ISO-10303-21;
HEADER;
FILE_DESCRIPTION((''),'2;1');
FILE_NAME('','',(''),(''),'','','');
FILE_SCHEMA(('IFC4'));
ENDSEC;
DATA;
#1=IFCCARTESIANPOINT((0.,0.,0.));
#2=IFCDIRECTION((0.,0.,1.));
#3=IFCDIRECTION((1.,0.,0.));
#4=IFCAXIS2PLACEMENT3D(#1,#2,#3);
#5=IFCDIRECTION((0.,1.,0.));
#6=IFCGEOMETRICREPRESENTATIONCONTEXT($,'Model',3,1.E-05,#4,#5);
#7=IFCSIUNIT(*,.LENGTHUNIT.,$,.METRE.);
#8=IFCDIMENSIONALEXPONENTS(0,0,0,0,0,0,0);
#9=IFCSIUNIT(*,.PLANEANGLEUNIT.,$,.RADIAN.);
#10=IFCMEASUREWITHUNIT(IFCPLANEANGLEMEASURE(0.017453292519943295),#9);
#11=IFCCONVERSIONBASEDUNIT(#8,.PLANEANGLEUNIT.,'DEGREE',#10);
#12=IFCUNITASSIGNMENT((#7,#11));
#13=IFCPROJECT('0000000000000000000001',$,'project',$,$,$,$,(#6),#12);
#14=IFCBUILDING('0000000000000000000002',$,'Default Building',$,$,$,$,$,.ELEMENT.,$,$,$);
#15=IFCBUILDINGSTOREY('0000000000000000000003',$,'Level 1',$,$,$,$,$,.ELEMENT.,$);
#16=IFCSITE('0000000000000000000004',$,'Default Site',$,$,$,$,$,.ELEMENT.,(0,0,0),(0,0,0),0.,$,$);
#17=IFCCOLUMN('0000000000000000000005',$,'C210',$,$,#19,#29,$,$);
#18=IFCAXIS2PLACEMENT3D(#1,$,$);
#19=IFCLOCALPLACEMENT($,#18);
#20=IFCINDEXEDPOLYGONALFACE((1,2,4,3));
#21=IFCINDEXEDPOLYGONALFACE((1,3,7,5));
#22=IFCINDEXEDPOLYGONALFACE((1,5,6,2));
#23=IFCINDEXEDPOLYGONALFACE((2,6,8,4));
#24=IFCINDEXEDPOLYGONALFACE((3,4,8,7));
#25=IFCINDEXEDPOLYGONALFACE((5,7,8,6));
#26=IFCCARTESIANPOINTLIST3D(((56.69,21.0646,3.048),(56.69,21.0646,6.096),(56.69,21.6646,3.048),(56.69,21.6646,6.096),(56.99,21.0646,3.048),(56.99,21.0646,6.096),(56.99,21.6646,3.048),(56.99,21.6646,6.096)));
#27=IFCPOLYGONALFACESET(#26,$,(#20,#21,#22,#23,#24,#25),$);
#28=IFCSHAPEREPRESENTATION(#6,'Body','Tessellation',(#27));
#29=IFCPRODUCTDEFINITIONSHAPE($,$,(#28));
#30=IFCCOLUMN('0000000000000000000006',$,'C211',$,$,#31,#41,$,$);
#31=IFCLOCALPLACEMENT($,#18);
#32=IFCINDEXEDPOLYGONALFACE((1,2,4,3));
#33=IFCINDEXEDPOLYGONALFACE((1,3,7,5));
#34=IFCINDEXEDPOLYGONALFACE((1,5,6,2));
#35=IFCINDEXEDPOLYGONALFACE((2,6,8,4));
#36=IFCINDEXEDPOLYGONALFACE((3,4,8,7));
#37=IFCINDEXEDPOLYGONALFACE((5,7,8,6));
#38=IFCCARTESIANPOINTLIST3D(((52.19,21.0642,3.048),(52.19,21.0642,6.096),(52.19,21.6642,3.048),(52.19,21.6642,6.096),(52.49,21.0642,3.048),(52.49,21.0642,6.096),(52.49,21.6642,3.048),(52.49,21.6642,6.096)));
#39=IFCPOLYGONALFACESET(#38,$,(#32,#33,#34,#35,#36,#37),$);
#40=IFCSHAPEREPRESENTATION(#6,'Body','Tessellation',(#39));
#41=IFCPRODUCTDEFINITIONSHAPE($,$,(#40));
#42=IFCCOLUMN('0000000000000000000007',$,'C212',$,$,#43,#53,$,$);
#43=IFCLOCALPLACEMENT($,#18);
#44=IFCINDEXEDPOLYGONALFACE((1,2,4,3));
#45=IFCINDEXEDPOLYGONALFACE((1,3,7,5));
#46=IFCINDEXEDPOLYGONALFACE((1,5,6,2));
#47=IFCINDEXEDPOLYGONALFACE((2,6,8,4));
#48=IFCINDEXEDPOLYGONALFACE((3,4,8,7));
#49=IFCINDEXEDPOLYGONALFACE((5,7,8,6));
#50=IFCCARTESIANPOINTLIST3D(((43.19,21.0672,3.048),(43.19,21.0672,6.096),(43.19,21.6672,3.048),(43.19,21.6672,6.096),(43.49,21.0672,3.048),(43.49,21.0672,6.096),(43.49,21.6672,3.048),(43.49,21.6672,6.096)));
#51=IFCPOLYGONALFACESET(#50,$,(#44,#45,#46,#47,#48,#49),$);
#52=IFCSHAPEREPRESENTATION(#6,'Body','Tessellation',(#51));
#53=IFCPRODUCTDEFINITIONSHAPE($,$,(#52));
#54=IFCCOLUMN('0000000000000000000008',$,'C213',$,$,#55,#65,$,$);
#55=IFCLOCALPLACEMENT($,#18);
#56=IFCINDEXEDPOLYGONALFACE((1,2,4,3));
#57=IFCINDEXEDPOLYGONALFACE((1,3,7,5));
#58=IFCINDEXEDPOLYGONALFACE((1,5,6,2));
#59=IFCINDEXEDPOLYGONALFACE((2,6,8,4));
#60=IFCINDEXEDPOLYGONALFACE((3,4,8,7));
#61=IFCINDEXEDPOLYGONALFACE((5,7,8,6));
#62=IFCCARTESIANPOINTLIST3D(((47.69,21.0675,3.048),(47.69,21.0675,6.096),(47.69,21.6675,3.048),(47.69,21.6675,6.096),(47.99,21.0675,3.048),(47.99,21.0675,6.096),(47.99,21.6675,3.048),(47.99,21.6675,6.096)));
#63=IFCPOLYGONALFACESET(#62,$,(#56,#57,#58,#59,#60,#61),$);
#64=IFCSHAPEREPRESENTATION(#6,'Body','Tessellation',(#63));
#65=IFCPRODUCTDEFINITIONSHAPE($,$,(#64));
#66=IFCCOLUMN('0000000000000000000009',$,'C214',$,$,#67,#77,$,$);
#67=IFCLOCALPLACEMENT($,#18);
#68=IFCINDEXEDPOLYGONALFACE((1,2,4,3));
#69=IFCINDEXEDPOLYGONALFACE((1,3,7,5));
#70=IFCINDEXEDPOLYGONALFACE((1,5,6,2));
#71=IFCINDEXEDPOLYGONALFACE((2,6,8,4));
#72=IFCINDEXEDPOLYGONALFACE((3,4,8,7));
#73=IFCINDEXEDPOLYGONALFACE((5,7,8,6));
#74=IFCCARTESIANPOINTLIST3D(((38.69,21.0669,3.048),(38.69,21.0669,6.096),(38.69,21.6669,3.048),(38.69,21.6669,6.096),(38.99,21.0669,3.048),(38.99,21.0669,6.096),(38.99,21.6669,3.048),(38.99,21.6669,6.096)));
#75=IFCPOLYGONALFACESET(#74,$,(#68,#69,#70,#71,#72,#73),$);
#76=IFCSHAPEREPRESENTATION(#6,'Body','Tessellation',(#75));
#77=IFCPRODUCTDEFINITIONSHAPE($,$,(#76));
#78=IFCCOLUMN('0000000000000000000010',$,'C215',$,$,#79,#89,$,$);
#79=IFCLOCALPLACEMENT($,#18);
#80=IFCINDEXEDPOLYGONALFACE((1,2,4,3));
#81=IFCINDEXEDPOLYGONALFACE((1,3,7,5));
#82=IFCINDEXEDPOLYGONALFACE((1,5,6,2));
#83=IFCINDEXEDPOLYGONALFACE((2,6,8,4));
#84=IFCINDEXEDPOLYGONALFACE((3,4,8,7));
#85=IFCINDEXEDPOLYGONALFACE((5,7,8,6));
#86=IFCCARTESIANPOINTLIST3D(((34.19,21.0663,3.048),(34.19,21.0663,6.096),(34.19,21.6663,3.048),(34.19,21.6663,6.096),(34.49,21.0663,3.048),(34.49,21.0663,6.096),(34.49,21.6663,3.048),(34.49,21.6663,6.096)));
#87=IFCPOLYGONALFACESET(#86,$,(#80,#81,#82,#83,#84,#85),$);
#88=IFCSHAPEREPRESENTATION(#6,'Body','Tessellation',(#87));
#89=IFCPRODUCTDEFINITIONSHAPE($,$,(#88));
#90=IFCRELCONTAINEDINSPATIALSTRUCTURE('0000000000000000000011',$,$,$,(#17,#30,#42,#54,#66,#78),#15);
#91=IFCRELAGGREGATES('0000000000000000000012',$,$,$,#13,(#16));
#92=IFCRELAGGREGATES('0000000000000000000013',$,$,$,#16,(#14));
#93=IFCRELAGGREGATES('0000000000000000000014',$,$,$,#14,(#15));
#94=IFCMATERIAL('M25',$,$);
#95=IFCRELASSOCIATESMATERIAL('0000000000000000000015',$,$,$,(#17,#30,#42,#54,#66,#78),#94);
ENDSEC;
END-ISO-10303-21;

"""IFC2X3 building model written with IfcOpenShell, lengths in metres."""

from ifc_helpers import new_model, entity, si_unit, converted_unit, direction, frame, frame_2d, origin_with_axes, place, context, project, spatial, rectangle, extrude, material, element, save


model = new_model("IFC2X3")

# Units and contexts
model_context = context("Model", 3, precision=1e-05, world=origin_with_axes(), true_north=direction((0.0, 1.0, 0.0)))
ifc_project = project(units=[si_unit("LENGTHUNIT", "METRE"), converted_unit("PLANEANGLEUNIT", "DEGREE", entity("IfcPlaneAngleMeasure", 0.017453292519943295), si_unit("PLANEANGLEUNIT", "RADIAN"), dimensions=[0, 0, 0, 0, 0, 0, 0])], contexts=[model_context])

# Site, building, storey
site = spatial("IfcSite", under=ifc_project, Name="Default Site", CompositionType="ELEMENT", RefLatitude=(0, 0, 0), RefLongitude=(0, 0, 0), RefElevation=0.0)
building = spatial("IfcBuilding", under=site, Name="Default Building", CompositionType="ELEMENT")
storey = spatial("IfcBuildingStorey", under=building, Name="Level 1", CompositionType="ELEMENT")

# Columns
ifc_material = material(Name="M25")
placement = place(None, origin_with_axes())
element("IfcColumn", 1, at=placement, inside=storey, material=ifc_material, Name="C210", context=model_context, shape_type="SweptSolid", body=[
    extrude(rectangle(XDim=0.3, YDim=0.6, at=frame_2d((0.0, 0.0), x_axis=(1.0, 0.0, 0.0))), frame((56.84, 21.3646, 3.048), z_axis=(0.0, 0.0, 1.0), x_axis=(1.0, 0.0, 0.0)), (0.0, 0.0, 1.0), 3.048),
])
element("IfcColumn", 2, at=placement, inside=storey, material=ifc_material, Name="C211", context=model_context, shape_type="SweptSolid", body=[
    extrude(rectangle(XDim=0.3, YDim=0.6, at=frame_2d((0.0, 0.0), x_axis=(1.0, 0.0, 0.0))), frame((52.34, 21.3642, 3.048), z_axis=(0.0, 0.0, 1.0), x_axis=(1.0, 0.0, 0.0)), (0.0, 0.0, 1.0), 3.048),
])
element("IfcColumn", 3, at=placement, inside=storey, material=ifc_material, Name="C212", context=model_context, shape_type="SweptSolid", body=[
    extrude(rectangle(XDim=0.3, YDim=0.6, at=frame_2d((0.0, 0.0), x_axis=(1.0, 0.0, 0.0))), frame((43.34, 21.3672, 3.048), z_axis=(0.0, 0.0, 1.0), x_axis=(1.0, 0.0, 0.0)), (0.0, 0.0, 1.0), 3.048),
])
element("IfcColumn", 4, at=placement, inside=storey, material=ifc_material, Name="C213", context=model_context, shape_type="SweptSolid", body=[
    extrude(rectangle(XDim=0.3, YDim=0.6, at=frame_2d((0.0, 0.0), x_axis=(1.0, 0.0, 0.0))), frame((47.84, 21.3675, 3.048), z_axis=(0.0, 0.0, 1.0), x_axis=(1.0, 0.0, 0.0)), (0.0, 0.0, 1.0), 3.048),
])
element("IfcColumn", 5, at=placement, inside=storey, material=ifc_material, Name="C214", context=model_context, shape_type="SweptSolid", body=[
    extrude(rectangle(XDim=0.3, YDim=0.6, at=frame_2d((0.0, 0.0), x_axis=(1.0, 0.0, 0.0))), frame((38.84, 21.3669, 3.048), z_axis=(0.0, 0.0, 1.0), x_axis=(1.0, 0.0, 0.0)), (0.0, 0.0, 1.0), 3.048),
])
element("IfcColumn", 6, at=placement, inside=storey, material=ifc_material, Name="C215", context=model_context, shape_type="SweptSolid", body=[
    extrude(rectangle(XDim=0.3, YDim=0.6, at=frame_2d((0.0, 0.0), x_axis=(1.0, 0.0, 0.0))), frame((34.34, 21.3663, 3.048), z_axis=(0.0, 0.0, 1.0), x_axis=(1.0, 0.0, 0.0)), (0.0, 0.0, 1.0), 3.048),
])

save(model, "model.ifc")
